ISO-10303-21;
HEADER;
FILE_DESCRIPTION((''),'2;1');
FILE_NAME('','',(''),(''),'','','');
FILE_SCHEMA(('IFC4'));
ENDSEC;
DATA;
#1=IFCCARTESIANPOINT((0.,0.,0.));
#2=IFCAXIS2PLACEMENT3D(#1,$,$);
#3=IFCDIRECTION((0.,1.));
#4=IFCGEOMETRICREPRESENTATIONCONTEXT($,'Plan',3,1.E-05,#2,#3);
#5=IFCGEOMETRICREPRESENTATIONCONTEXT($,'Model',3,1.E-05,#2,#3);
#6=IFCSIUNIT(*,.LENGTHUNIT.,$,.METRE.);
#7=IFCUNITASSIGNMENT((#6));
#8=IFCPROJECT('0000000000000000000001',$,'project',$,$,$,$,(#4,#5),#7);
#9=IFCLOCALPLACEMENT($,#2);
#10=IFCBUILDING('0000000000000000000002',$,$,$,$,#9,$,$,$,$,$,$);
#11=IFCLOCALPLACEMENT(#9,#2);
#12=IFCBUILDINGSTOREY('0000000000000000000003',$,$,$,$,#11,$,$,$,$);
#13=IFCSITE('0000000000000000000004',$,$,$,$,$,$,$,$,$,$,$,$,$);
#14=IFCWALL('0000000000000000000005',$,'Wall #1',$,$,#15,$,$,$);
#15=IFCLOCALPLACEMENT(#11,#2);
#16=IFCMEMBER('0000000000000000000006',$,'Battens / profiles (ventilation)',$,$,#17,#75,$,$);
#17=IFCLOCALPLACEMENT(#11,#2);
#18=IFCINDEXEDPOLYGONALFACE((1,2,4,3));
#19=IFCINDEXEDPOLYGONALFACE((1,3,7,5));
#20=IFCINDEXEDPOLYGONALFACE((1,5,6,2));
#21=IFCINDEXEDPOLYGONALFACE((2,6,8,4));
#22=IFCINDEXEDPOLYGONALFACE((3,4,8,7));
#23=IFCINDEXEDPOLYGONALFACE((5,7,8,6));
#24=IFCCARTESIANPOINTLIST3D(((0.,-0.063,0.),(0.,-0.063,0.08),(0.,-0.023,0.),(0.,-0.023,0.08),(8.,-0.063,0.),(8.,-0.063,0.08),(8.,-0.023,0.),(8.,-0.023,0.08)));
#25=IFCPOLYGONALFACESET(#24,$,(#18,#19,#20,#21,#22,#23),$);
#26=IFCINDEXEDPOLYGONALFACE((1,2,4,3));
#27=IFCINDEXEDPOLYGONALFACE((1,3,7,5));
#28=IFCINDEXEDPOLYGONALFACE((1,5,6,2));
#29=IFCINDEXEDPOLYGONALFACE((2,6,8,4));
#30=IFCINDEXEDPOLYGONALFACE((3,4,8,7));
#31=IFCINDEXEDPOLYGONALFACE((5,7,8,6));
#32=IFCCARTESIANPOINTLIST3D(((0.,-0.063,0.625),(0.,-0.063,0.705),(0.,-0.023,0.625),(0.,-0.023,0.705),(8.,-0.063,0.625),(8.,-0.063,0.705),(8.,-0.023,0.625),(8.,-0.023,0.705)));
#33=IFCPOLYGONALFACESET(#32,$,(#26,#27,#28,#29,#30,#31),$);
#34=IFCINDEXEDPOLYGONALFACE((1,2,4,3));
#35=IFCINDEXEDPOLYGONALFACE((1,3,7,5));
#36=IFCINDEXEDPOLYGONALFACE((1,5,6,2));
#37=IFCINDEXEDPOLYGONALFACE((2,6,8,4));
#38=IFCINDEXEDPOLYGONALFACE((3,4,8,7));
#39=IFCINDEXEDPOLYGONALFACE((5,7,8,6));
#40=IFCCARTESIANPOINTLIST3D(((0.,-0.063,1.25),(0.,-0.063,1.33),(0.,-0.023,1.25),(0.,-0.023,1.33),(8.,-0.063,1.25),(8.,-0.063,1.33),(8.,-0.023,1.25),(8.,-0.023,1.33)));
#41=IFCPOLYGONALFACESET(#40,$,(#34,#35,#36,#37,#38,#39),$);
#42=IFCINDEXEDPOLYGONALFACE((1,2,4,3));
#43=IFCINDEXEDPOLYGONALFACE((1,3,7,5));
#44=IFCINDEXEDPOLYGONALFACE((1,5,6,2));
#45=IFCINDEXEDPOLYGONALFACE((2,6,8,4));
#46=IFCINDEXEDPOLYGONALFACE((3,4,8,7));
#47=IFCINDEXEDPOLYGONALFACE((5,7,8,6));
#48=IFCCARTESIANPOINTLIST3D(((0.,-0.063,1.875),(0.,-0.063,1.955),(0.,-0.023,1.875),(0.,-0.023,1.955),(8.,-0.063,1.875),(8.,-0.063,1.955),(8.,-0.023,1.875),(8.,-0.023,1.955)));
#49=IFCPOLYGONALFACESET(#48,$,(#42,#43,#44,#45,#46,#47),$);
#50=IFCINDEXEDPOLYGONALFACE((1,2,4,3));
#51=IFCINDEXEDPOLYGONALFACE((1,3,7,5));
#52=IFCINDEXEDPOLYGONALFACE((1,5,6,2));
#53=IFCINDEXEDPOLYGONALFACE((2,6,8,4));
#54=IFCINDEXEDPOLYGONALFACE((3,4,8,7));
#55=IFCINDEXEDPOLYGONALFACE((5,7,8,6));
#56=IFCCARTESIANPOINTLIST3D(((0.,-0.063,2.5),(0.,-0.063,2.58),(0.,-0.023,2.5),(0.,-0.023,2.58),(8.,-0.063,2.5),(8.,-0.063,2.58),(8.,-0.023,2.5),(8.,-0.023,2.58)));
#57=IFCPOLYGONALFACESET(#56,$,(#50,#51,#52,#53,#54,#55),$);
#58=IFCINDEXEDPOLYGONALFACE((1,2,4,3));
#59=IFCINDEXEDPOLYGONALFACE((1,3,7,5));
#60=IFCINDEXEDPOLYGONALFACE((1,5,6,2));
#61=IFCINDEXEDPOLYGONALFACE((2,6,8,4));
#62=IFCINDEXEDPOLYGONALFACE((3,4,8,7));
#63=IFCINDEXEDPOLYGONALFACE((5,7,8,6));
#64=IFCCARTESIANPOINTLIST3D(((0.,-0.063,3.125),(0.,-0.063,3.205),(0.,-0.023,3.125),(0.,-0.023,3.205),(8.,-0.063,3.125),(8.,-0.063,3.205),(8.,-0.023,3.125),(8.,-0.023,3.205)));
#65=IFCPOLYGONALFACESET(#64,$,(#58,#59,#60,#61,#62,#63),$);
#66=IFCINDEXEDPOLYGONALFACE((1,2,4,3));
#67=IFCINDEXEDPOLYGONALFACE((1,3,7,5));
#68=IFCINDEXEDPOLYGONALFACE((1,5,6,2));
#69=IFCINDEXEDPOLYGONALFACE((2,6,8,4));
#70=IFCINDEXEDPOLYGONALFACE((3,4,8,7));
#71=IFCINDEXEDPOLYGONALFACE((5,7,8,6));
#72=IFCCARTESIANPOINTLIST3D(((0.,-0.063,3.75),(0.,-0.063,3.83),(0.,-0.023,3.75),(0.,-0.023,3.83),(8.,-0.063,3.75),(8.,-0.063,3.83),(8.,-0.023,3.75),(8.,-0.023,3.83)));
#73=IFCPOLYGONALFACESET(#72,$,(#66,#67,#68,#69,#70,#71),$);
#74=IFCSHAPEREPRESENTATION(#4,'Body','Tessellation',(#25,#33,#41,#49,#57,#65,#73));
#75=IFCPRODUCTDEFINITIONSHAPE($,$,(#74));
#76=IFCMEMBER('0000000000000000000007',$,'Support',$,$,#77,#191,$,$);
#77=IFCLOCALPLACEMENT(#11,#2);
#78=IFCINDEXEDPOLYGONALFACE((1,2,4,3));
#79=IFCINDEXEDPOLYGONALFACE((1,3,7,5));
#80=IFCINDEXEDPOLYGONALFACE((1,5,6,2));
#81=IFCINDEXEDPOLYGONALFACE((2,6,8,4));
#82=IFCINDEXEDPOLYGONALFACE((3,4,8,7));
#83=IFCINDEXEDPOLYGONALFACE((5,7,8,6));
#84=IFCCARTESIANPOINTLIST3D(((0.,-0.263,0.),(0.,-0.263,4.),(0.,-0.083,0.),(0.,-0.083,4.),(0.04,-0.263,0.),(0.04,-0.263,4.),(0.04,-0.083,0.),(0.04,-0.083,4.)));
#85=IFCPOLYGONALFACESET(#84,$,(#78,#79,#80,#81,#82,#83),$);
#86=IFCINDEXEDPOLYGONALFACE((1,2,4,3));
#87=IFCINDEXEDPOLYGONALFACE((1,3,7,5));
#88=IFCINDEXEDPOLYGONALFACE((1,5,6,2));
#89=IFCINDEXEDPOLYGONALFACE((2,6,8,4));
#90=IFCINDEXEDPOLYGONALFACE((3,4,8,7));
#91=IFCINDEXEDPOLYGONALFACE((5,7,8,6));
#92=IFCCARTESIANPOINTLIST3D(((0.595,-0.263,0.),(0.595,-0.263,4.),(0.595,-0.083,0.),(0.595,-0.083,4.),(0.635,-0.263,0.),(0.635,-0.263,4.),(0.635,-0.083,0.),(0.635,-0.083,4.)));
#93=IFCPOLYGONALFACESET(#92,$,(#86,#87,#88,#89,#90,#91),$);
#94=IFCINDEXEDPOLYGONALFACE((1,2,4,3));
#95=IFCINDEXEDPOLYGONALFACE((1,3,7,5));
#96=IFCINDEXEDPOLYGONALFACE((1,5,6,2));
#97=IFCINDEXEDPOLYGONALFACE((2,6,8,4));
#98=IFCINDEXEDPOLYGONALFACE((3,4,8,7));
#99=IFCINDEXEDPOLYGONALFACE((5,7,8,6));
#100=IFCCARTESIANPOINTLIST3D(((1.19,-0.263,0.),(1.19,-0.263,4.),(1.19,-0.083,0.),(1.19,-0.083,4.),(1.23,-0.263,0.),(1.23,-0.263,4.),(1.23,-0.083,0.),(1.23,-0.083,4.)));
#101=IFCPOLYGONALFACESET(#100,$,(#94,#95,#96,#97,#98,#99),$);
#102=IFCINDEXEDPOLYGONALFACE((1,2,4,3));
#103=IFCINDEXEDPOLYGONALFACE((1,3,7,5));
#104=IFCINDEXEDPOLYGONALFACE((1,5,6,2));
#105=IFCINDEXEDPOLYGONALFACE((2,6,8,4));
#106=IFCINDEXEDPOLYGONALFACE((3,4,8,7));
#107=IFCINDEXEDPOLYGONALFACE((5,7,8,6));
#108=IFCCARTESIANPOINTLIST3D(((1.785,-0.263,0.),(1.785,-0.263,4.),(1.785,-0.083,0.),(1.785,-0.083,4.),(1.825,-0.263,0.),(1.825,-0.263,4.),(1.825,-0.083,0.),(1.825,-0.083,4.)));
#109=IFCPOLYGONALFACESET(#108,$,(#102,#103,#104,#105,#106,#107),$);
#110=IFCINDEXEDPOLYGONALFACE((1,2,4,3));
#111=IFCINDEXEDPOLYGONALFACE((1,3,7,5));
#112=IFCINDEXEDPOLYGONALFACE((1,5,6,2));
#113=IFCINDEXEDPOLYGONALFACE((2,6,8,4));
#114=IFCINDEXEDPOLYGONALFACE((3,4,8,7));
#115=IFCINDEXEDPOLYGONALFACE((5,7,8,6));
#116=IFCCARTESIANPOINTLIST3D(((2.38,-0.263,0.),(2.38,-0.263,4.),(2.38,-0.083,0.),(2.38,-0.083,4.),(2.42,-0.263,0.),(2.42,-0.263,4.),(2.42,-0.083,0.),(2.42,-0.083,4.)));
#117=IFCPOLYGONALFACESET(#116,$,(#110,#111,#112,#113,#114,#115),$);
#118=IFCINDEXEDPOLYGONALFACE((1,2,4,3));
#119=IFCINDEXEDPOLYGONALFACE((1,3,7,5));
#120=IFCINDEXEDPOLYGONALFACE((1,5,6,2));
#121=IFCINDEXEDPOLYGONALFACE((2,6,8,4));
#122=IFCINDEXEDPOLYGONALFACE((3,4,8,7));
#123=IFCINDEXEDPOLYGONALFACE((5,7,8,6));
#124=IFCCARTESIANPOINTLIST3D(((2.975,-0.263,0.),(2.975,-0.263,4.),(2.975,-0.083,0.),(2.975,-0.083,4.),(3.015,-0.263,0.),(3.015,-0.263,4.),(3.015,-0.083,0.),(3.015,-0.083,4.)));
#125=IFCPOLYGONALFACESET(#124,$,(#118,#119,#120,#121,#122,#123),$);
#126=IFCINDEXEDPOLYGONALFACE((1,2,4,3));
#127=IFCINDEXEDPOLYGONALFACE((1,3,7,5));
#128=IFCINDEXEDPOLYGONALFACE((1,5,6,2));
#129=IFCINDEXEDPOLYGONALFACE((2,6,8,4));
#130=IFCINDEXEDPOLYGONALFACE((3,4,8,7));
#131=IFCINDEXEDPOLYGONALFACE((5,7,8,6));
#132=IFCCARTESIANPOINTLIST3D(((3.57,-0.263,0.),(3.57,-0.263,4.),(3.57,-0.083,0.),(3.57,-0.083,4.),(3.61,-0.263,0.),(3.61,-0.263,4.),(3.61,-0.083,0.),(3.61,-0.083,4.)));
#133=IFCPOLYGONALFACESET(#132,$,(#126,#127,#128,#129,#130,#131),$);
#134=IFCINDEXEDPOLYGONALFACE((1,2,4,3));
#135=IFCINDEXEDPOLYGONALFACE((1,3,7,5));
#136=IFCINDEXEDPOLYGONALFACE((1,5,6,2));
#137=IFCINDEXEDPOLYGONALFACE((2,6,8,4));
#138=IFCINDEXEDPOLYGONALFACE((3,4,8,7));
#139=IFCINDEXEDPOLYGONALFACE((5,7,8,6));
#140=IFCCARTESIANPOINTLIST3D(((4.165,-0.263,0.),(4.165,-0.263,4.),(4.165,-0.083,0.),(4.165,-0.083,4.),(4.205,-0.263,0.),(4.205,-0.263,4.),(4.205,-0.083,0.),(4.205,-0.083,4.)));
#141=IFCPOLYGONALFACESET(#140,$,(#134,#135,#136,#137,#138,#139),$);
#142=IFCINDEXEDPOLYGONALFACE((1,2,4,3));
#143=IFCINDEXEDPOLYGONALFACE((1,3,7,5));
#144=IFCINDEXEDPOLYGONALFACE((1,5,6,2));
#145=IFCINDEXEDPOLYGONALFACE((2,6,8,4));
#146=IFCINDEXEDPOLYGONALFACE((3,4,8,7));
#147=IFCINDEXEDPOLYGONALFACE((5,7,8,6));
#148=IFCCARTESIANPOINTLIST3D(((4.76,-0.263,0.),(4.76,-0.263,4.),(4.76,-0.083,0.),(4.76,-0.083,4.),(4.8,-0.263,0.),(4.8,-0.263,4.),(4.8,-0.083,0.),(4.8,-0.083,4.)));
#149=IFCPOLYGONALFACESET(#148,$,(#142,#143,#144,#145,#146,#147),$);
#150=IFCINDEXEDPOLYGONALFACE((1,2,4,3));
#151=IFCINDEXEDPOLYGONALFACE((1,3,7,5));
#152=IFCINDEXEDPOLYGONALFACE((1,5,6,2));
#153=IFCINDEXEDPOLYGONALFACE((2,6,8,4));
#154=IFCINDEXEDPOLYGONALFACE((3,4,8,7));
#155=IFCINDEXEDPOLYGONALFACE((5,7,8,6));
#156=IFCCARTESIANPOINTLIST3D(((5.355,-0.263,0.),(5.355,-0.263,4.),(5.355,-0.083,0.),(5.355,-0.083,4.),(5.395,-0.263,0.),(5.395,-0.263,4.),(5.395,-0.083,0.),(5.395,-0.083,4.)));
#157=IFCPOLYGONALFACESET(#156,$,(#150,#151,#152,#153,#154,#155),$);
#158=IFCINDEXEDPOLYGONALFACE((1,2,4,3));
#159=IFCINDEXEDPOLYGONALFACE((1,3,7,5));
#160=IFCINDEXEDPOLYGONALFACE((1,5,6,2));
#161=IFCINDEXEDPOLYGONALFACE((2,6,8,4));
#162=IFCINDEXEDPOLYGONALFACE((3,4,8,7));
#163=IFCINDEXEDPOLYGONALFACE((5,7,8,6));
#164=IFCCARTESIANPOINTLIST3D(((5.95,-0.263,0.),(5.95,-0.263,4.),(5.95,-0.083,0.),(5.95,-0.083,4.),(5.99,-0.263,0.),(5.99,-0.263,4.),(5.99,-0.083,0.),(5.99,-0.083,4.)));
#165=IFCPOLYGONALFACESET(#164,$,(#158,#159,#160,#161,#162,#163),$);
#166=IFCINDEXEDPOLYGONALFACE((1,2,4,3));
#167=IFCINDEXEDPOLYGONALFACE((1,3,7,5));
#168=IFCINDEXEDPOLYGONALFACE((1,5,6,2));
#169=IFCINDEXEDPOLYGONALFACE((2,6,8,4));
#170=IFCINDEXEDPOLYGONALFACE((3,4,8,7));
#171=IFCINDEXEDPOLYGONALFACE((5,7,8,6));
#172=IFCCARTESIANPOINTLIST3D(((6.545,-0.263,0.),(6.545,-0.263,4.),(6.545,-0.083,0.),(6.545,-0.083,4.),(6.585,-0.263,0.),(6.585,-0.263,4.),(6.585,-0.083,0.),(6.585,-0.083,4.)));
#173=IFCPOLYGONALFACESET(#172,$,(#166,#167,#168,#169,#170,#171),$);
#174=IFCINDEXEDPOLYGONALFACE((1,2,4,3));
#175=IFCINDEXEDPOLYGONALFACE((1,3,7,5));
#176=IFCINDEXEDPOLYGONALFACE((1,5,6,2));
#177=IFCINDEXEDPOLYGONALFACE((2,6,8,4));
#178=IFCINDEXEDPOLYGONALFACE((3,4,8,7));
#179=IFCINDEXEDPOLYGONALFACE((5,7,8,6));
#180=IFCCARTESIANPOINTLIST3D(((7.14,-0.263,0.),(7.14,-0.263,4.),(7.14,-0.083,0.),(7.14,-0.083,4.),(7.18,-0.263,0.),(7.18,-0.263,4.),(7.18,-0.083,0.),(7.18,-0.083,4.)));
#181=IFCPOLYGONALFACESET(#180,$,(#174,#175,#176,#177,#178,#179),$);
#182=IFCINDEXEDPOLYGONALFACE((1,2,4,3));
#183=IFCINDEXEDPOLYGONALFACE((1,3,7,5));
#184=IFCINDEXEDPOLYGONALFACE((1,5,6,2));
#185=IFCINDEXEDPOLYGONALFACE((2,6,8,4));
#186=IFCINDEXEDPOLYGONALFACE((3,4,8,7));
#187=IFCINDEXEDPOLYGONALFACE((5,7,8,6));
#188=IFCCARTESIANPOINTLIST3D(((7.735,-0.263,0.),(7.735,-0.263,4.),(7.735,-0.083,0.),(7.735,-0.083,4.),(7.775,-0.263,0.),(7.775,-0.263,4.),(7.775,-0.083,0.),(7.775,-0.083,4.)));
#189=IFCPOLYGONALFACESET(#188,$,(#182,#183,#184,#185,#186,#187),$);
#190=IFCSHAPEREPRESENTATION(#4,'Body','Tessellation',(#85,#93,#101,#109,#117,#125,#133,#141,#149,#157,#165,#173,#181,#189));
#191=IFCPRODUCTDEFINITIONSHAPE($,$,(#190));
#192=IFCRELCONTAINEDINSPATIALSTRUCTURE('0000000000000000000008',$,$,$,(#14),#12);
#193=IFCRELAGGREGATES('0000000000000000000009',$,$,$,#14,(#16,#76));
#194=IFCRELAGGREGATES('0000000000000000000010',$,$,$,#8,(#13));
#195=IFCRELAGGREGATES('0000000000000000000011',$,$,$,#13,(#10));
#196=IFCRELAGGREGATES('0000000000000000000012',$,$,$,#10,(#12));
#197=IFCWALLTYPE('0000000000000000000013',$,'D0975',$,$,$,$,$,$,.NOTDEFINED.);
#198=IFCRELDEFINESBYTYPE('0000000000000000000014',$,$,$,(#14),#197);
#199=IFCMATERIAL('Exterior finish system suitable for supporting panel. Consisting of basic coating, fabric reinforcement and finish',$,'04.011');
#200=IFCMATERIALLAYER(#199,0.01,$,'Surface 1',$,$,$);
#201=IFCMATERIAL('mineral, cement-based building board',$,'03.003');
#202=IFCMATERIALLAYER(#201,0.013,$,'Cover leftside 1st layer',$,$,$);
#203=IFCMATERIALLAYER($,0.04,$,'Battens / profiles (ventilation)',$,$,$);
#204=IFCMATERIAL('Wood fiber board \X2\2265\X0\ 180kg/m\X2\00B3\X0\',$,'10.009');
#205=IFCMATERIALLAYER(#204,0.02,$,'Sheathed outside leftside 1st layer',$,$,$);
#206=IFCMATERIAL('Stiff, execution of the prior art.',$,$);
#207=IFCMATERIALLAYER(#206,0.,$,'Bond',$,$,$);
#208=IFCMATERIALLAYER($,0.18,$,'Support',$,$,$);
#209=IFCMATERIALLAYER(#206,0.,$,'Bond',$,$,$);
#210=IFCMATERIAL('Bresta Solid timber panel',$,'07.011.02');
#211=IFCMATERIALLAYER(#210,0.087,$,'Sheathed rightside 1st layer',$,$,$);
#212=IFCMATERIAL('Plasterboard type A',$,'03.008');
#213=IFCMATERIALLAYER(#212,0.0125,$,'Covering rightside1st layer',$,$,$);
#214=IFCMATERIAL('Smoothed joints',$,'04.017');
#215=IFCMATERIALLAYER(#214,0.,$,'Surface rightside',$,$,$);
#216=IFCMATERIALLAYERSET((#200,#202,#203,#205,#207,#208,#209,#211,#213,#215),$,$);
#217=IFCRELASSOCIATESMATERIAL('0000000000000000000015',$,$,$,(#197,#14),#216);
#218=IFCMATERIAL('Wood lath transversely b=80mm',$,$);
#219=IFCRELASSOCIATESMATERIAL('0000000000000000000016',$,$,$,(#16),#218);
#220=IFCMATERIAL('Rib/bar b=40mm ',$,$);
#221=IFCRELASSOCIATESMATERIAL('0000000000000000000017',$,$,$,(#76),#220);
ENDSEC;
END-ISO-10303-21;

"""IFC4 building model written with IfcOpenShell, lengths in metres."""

from ifc_helpers import new_model, si_unit, direction, frame, frame_2d, origin, place, context, project, spatial, rectangle, extrude, material, layer, layer_set, type_object, element, aggregate, save


model = new_model("IFC4")

# Units and contexts
plan_context = context("Plan", 3, precision=1e-05, world=origin(), true_north=direction((0.0, 1.0)))
model_context = context("Model", 3, precision=1e-05, world=origin(), true_north=direction((0.0, 1.0)))
ifc_project = project(units=[si_unit("LENGTHUNIT", "METRE")], contexts=[plan_context, model_context])

# Site, building, storey
site = spatial("IfcSite", under=ifc_project)
building_placement = place(None, origin())
building = spatial("IfcBuilding", under=site, at=building_placement)
storey_placement = place(building_placement, origin())
storey = spatial("IfcBuildingStorey", under=building, at=storey_placement)

# Wall, members
ifc_material_1 = material(Name="Exterior finish system suitable for supporting panel. Consisting of basic coating, fabric reinforcement and finish", Category="04.011")
ifc_layer_1 = layer(ifc_material_1, 0.01, Name="Surface 1")
ifc_material_2 = material(Name="mineral, cement-based building board", Category="03.003")
ifc_layer_2 = layer(ifc_material_2, 0.013, Name="Cover leftside 1st layer")
ifc_layer_3 = layer(None, 0.04, Name="Battens / profiles (ventilation)")
ifc_material_3 = material(Name="Wood fiber board ≥ 180kg/m³", Category="10.009")
ifc_layer_4 = layer(ifc_material_3, 0.02, Name="Sheathed outside leftside 1st layer")
ifc_material_4 = material(Name="Stiff, execution of the prior art.")
ifc_layer_5 = layer(ifc_material_4, 0.0, Name="Bond")
ifc_layer_6 = layer(None, 0.18, Name="Support")
ifc_layer_7 = layer(ifc_material_4, 0.0, Name="Bond")
ifc_material_5 = material(Name="Bresta Solid timber panel", Category="07.011.02")
ifc_layer_8 = layer(ifc_material_5, 0.087, Name="Sheathed rightside 1st layer")
ifc_material_6 = material(Name="Plasterboard type A", Category="03.008")
ifc_layer_9 = layer(ifc_material_6, 0.0125, Name="Covering rightside1st layer")
ifc_material_7 = material(Name="Smoothed joints", Category="04.017")
ifc_layer_10 = layer(ifc_material_7, 0.0, Name="Surface rightside")
ifc_layer_set = layer_set([ifc_layer_1, ifc_layer_2, ifc_layer_3, ifc_layer_4, ifc_layer_5, ifc_layer_6, ifc_layer_7, ifc_layer_8, ifc_layer_9, ifc_layer_10])
wall_type = type_object("IfcWallType", Name="D0975", PredefinedType="NOTDEFINED", material=ifc_layer_set)
wall_placement = place(None, frame((0.0, 0.0, 0.0), z_axis=(0.0, -1.0, 0.0), x_axis=(1.0, 0.0, 0.0)))
wall = element("IfcWall", 1, at=wall_placement, inside=storey, type_object=wall_type, material=ifc_layer_set, Name="Wall #1")
ifc_material_8 = material(Name="Wood lath transversely b=80mm")
member_1_placement = place(wall_placement, origin())
member_1 = element("IfcMember", 2, at=member_1_placement, material=ifc_material_8, Name="Battens / profiles (ventilation)", context=plan_context, shape_type="SweptSolid", body=[
    extrude(rectangle(XDim=0.08, YDim=0.04, at=frame_2d((0.04, 0.02), x_axis=(1.0, 0.0))), frame((0.0, 0.0, 0.023), z_axis=(1.0, 0.0, 0.0), x_axis=(0.0, 1.0, 0.0)), (0.0, 0.0, 1.0), 8.0),
    extrude(rectangle(XDim=0.08, YDim=0.04, at=frame_2d((0.04, 0.02), x_axis=(1.0, 0.0))), frame((0.0, 0.625, 0.023), z_axis=(1.0, 0.0, 0.0), x_axis=(0.0, 1.0, 0.0)), (0.0, 0.0, 1.0), 8.0),
    extrude(rectangle(XDim=0.08, YDim=0.04, at=frame_2d((0.04, 0.02), x_axis=(1.0, 0.0))), frame((0.0, 1.25, 0.023), z_axis=(1.0, 0.0, 0.0), x_axis=(0.0, 1.0, 0.0)), (0.0, 0.0, 1.0), 8.0),
    extrude(rectangle(XDim=0.08, YDim=0.04, at=frame_2d((0.04, 0.02), x_axis=(1.0, 0.0))), frame((0.0, 1.875, 0.023), z_axis=(1.0, 0.0, 0.0), x_axis=(0.0, 1.0, 0.0)), (0.0, 0.0, 1.0), 8.0),
    extrude(rectangle(XDim=0.08, YDim=0.04, at=frame_2d((0.04, 0.02), x_axis=(1.0, 0.0))), frame((0.0, 2.5, 0.023), z_axis=(1.0, 0.0, 0.0), x_axis=(0.0, 1.0, 0.0)), (0.0, 0.0, 1.0), 8.0),
    extrude(rectangle(XDim=0.08, YDim=0.04, at=frame_2d((0.04, 0.02), x_axis=(1.0, 0.0))), frame((0.0, 3.125, 0.023), z_axis=(1.0, 0.0, 0.0), x_axis=(0.0, 1.0, 0.0)), (0.0, 0.0, 1.0), 8.0),
    extrude(rectangle(XDim=0.08, YDim=0.04, at=frame_2d((0.04, 0.02), x_axis=(1.0, 0.0))), frame((0.0, 3.75, 0.023), z_axis=(1.0, 0.0, 0.0), x_axis=(0.0, 1.0, 0.0)), (0.0, 0.0, 1.0), 8.0),
])
ifc_material_9 = material(Name="Rib/bar b=40mm ")
member_2_placement = place(wall_placement, origin())
member_2 = element("IfcMember", 3, at=member_2_placement, material=ifc_material_9, Name="Support", context=plan_context, shape_type="SweptSolid", body=[
    extrude(rectangle(XDim=0.04, YDim=0.18, at=frame_2d((0.02, 0.09), x_axis=(1.0, 0.0))), frame((0.0, 4.0, 0.083), z_axis=(0.0, -1.0, 0.0), x_axis=(1.0, 0.0, 0.0)), (0.0, 0.0, 1.0), 4.0),
    extrude(rectangle(XDim=0.04, YDim=0.18, at=frame_2d((0.02, 0.09), x_axis=(1.0, 0.0))), frame((0.595, 4.0, 0.083), z_axis=(0.0, -1.0, 0.0), x_axis=(1.0, 0.0, 0.0)), (0.0, 0.0, 1.0), 4.0),
    extrude(rectangle(XDim=0.04, YDim=0.18, at=frame_2d((0.02, 0.09), x_axis=(1.0, 0.0))), frame((1.19, 4.0, 0.083), z_axis=(0.0, -1.0, 0.0), x_axis=(1.0, 0.0, 0.0)), (0.0, 0.0, 1.0), 4.0),
    extrude(rectangle(XDim=0.04, YDim=0.18, at=frame_2d((0.02, 0.09), x_axis=(1.0, 0.0))), frame((1.785, 4.0, 0.083), z_axis=(0.0, -1.0, 0.0), x_axis=(1.0, 0.0, 0.0)), (0.0, 0.0, 1.0), 4.0),
    extrude(rectangle(XDim=0.04, YDim=0.18, at=frame_2d((0.02, 0.09), x_axis=(1.0, 0.0))), frame((2.38, 4.0, 0.083), z_axis=(0.0, -1.0, 0.0), x_axis=(1.0, 0.0, 0.0)), (0.0, 0.0, 1.0), 4.0),
    extrude(rectangle(XDim=0.04, YDim=0.18, at=frame_2d((0.02, 0.09), x_axis=(1.0, 0.0))), frame((2.975, 4.0, 0.083), z_axis=(0.0, -1.0, 0.0), x_axis=(1.0, 0.0, 0.0)), (0.0, 0.0, 1.0), 4.0),
    extrude(rectangle(XDim=0.04, YDim=0.18, at=frame_2d((0.02, 0.09), x_axis=(1.0, 0.0))), frame((3.57, 4.0, 0.083), z_axis=(0.0, -1.0, 0.0), x_axis=(1.0, 0.0, 0.0)), (0.0, 0.0, 1.0), 4.0),
    extrude(rectangle(XDim=0.04, YDim=0.18, at=frame_2d((0.02, 0.09), x_axis=(1.0, 0.0))), frame((4.165, 4.0, 0.083), z_axis=(0.0, -1.0, 0.0), x_axis=(1.0, 0.0, 0.0)), (0.0, 0.0, 1.0), 4.0),
    extrude(rectangle(XDim=0.04, YDim=0.18, at=frame_2d((0.02, 0.09), x_axis=(1.0, 0.0))), frame((4.76, 4.0, 0.083), z_axis=(0.0, -1.0, 0.0), x_axis=(1.0, 0.0, 0.0)), (0.0, 0.0, 1.0), 4.0),
    extrude(rectangle(XDim=0.04, YDim=0.18, at=frame_2d((0.02, 0.09), x_axis=(1.0, 0.0))), frame((5.355, 4.0, 0.083), z_axis=(0.0, -1.0, 0.0), x_axis=(1.0, 0.0, 0.0)), (0.0, 0.0, 1.0), 4.0),
    extrude(rectangle(XDim=0.04, YDim=0.18, at=frame_2d((0.02, 0.09), x_axis=(1.0, 0.0))), frame((5.95, 4.0, 0.083), z_axis=(0.0, -1.0, 0.0), x_axis=(1.0, 0.0, 0.0)), (0.0, 0.0, 1.0), 4.0),
    extrude(rectangle(XDim=0.04, YDim=0.18, at=frame_2d((0.02, 0.09), x_axis=(1.0, 0.0))), frame((6.545, 4.0, 0.083), z_axis=(0.0, -1.0, 0.0), x_axis=(1.0, 0.0, 0.0)), (0.0, 0.0, 1.0), 4.0),
    extrude(rectangle(XDim=0.04, YDim=0.18, at=frame_2d((0.02, 0.09), x_axis=(1.0, 0.0))), frame((7.14, 4.0, 0.083), z_axis=(0.0, -1.0, 0.0), x_axis=(1.0, 0.0, 0.0)), (0.0, 0.0, 1.0), 4.0),
    extrude(rectangle(XDim=0.04, YDim=0.18, at=frame_2d((0.02, 0.09), x_axis=(1.0, 0.0))), frame((7.735, 4.0, 0.083), z_axis=(0.0, -1.0, 0.0), x_axis=(1.0, 0.0, 0.0)), (0.0, 0.0, 1.0), 4.0),
])
aggregate(wall, [member_1, member_2])

save(model, "model.ifc")
